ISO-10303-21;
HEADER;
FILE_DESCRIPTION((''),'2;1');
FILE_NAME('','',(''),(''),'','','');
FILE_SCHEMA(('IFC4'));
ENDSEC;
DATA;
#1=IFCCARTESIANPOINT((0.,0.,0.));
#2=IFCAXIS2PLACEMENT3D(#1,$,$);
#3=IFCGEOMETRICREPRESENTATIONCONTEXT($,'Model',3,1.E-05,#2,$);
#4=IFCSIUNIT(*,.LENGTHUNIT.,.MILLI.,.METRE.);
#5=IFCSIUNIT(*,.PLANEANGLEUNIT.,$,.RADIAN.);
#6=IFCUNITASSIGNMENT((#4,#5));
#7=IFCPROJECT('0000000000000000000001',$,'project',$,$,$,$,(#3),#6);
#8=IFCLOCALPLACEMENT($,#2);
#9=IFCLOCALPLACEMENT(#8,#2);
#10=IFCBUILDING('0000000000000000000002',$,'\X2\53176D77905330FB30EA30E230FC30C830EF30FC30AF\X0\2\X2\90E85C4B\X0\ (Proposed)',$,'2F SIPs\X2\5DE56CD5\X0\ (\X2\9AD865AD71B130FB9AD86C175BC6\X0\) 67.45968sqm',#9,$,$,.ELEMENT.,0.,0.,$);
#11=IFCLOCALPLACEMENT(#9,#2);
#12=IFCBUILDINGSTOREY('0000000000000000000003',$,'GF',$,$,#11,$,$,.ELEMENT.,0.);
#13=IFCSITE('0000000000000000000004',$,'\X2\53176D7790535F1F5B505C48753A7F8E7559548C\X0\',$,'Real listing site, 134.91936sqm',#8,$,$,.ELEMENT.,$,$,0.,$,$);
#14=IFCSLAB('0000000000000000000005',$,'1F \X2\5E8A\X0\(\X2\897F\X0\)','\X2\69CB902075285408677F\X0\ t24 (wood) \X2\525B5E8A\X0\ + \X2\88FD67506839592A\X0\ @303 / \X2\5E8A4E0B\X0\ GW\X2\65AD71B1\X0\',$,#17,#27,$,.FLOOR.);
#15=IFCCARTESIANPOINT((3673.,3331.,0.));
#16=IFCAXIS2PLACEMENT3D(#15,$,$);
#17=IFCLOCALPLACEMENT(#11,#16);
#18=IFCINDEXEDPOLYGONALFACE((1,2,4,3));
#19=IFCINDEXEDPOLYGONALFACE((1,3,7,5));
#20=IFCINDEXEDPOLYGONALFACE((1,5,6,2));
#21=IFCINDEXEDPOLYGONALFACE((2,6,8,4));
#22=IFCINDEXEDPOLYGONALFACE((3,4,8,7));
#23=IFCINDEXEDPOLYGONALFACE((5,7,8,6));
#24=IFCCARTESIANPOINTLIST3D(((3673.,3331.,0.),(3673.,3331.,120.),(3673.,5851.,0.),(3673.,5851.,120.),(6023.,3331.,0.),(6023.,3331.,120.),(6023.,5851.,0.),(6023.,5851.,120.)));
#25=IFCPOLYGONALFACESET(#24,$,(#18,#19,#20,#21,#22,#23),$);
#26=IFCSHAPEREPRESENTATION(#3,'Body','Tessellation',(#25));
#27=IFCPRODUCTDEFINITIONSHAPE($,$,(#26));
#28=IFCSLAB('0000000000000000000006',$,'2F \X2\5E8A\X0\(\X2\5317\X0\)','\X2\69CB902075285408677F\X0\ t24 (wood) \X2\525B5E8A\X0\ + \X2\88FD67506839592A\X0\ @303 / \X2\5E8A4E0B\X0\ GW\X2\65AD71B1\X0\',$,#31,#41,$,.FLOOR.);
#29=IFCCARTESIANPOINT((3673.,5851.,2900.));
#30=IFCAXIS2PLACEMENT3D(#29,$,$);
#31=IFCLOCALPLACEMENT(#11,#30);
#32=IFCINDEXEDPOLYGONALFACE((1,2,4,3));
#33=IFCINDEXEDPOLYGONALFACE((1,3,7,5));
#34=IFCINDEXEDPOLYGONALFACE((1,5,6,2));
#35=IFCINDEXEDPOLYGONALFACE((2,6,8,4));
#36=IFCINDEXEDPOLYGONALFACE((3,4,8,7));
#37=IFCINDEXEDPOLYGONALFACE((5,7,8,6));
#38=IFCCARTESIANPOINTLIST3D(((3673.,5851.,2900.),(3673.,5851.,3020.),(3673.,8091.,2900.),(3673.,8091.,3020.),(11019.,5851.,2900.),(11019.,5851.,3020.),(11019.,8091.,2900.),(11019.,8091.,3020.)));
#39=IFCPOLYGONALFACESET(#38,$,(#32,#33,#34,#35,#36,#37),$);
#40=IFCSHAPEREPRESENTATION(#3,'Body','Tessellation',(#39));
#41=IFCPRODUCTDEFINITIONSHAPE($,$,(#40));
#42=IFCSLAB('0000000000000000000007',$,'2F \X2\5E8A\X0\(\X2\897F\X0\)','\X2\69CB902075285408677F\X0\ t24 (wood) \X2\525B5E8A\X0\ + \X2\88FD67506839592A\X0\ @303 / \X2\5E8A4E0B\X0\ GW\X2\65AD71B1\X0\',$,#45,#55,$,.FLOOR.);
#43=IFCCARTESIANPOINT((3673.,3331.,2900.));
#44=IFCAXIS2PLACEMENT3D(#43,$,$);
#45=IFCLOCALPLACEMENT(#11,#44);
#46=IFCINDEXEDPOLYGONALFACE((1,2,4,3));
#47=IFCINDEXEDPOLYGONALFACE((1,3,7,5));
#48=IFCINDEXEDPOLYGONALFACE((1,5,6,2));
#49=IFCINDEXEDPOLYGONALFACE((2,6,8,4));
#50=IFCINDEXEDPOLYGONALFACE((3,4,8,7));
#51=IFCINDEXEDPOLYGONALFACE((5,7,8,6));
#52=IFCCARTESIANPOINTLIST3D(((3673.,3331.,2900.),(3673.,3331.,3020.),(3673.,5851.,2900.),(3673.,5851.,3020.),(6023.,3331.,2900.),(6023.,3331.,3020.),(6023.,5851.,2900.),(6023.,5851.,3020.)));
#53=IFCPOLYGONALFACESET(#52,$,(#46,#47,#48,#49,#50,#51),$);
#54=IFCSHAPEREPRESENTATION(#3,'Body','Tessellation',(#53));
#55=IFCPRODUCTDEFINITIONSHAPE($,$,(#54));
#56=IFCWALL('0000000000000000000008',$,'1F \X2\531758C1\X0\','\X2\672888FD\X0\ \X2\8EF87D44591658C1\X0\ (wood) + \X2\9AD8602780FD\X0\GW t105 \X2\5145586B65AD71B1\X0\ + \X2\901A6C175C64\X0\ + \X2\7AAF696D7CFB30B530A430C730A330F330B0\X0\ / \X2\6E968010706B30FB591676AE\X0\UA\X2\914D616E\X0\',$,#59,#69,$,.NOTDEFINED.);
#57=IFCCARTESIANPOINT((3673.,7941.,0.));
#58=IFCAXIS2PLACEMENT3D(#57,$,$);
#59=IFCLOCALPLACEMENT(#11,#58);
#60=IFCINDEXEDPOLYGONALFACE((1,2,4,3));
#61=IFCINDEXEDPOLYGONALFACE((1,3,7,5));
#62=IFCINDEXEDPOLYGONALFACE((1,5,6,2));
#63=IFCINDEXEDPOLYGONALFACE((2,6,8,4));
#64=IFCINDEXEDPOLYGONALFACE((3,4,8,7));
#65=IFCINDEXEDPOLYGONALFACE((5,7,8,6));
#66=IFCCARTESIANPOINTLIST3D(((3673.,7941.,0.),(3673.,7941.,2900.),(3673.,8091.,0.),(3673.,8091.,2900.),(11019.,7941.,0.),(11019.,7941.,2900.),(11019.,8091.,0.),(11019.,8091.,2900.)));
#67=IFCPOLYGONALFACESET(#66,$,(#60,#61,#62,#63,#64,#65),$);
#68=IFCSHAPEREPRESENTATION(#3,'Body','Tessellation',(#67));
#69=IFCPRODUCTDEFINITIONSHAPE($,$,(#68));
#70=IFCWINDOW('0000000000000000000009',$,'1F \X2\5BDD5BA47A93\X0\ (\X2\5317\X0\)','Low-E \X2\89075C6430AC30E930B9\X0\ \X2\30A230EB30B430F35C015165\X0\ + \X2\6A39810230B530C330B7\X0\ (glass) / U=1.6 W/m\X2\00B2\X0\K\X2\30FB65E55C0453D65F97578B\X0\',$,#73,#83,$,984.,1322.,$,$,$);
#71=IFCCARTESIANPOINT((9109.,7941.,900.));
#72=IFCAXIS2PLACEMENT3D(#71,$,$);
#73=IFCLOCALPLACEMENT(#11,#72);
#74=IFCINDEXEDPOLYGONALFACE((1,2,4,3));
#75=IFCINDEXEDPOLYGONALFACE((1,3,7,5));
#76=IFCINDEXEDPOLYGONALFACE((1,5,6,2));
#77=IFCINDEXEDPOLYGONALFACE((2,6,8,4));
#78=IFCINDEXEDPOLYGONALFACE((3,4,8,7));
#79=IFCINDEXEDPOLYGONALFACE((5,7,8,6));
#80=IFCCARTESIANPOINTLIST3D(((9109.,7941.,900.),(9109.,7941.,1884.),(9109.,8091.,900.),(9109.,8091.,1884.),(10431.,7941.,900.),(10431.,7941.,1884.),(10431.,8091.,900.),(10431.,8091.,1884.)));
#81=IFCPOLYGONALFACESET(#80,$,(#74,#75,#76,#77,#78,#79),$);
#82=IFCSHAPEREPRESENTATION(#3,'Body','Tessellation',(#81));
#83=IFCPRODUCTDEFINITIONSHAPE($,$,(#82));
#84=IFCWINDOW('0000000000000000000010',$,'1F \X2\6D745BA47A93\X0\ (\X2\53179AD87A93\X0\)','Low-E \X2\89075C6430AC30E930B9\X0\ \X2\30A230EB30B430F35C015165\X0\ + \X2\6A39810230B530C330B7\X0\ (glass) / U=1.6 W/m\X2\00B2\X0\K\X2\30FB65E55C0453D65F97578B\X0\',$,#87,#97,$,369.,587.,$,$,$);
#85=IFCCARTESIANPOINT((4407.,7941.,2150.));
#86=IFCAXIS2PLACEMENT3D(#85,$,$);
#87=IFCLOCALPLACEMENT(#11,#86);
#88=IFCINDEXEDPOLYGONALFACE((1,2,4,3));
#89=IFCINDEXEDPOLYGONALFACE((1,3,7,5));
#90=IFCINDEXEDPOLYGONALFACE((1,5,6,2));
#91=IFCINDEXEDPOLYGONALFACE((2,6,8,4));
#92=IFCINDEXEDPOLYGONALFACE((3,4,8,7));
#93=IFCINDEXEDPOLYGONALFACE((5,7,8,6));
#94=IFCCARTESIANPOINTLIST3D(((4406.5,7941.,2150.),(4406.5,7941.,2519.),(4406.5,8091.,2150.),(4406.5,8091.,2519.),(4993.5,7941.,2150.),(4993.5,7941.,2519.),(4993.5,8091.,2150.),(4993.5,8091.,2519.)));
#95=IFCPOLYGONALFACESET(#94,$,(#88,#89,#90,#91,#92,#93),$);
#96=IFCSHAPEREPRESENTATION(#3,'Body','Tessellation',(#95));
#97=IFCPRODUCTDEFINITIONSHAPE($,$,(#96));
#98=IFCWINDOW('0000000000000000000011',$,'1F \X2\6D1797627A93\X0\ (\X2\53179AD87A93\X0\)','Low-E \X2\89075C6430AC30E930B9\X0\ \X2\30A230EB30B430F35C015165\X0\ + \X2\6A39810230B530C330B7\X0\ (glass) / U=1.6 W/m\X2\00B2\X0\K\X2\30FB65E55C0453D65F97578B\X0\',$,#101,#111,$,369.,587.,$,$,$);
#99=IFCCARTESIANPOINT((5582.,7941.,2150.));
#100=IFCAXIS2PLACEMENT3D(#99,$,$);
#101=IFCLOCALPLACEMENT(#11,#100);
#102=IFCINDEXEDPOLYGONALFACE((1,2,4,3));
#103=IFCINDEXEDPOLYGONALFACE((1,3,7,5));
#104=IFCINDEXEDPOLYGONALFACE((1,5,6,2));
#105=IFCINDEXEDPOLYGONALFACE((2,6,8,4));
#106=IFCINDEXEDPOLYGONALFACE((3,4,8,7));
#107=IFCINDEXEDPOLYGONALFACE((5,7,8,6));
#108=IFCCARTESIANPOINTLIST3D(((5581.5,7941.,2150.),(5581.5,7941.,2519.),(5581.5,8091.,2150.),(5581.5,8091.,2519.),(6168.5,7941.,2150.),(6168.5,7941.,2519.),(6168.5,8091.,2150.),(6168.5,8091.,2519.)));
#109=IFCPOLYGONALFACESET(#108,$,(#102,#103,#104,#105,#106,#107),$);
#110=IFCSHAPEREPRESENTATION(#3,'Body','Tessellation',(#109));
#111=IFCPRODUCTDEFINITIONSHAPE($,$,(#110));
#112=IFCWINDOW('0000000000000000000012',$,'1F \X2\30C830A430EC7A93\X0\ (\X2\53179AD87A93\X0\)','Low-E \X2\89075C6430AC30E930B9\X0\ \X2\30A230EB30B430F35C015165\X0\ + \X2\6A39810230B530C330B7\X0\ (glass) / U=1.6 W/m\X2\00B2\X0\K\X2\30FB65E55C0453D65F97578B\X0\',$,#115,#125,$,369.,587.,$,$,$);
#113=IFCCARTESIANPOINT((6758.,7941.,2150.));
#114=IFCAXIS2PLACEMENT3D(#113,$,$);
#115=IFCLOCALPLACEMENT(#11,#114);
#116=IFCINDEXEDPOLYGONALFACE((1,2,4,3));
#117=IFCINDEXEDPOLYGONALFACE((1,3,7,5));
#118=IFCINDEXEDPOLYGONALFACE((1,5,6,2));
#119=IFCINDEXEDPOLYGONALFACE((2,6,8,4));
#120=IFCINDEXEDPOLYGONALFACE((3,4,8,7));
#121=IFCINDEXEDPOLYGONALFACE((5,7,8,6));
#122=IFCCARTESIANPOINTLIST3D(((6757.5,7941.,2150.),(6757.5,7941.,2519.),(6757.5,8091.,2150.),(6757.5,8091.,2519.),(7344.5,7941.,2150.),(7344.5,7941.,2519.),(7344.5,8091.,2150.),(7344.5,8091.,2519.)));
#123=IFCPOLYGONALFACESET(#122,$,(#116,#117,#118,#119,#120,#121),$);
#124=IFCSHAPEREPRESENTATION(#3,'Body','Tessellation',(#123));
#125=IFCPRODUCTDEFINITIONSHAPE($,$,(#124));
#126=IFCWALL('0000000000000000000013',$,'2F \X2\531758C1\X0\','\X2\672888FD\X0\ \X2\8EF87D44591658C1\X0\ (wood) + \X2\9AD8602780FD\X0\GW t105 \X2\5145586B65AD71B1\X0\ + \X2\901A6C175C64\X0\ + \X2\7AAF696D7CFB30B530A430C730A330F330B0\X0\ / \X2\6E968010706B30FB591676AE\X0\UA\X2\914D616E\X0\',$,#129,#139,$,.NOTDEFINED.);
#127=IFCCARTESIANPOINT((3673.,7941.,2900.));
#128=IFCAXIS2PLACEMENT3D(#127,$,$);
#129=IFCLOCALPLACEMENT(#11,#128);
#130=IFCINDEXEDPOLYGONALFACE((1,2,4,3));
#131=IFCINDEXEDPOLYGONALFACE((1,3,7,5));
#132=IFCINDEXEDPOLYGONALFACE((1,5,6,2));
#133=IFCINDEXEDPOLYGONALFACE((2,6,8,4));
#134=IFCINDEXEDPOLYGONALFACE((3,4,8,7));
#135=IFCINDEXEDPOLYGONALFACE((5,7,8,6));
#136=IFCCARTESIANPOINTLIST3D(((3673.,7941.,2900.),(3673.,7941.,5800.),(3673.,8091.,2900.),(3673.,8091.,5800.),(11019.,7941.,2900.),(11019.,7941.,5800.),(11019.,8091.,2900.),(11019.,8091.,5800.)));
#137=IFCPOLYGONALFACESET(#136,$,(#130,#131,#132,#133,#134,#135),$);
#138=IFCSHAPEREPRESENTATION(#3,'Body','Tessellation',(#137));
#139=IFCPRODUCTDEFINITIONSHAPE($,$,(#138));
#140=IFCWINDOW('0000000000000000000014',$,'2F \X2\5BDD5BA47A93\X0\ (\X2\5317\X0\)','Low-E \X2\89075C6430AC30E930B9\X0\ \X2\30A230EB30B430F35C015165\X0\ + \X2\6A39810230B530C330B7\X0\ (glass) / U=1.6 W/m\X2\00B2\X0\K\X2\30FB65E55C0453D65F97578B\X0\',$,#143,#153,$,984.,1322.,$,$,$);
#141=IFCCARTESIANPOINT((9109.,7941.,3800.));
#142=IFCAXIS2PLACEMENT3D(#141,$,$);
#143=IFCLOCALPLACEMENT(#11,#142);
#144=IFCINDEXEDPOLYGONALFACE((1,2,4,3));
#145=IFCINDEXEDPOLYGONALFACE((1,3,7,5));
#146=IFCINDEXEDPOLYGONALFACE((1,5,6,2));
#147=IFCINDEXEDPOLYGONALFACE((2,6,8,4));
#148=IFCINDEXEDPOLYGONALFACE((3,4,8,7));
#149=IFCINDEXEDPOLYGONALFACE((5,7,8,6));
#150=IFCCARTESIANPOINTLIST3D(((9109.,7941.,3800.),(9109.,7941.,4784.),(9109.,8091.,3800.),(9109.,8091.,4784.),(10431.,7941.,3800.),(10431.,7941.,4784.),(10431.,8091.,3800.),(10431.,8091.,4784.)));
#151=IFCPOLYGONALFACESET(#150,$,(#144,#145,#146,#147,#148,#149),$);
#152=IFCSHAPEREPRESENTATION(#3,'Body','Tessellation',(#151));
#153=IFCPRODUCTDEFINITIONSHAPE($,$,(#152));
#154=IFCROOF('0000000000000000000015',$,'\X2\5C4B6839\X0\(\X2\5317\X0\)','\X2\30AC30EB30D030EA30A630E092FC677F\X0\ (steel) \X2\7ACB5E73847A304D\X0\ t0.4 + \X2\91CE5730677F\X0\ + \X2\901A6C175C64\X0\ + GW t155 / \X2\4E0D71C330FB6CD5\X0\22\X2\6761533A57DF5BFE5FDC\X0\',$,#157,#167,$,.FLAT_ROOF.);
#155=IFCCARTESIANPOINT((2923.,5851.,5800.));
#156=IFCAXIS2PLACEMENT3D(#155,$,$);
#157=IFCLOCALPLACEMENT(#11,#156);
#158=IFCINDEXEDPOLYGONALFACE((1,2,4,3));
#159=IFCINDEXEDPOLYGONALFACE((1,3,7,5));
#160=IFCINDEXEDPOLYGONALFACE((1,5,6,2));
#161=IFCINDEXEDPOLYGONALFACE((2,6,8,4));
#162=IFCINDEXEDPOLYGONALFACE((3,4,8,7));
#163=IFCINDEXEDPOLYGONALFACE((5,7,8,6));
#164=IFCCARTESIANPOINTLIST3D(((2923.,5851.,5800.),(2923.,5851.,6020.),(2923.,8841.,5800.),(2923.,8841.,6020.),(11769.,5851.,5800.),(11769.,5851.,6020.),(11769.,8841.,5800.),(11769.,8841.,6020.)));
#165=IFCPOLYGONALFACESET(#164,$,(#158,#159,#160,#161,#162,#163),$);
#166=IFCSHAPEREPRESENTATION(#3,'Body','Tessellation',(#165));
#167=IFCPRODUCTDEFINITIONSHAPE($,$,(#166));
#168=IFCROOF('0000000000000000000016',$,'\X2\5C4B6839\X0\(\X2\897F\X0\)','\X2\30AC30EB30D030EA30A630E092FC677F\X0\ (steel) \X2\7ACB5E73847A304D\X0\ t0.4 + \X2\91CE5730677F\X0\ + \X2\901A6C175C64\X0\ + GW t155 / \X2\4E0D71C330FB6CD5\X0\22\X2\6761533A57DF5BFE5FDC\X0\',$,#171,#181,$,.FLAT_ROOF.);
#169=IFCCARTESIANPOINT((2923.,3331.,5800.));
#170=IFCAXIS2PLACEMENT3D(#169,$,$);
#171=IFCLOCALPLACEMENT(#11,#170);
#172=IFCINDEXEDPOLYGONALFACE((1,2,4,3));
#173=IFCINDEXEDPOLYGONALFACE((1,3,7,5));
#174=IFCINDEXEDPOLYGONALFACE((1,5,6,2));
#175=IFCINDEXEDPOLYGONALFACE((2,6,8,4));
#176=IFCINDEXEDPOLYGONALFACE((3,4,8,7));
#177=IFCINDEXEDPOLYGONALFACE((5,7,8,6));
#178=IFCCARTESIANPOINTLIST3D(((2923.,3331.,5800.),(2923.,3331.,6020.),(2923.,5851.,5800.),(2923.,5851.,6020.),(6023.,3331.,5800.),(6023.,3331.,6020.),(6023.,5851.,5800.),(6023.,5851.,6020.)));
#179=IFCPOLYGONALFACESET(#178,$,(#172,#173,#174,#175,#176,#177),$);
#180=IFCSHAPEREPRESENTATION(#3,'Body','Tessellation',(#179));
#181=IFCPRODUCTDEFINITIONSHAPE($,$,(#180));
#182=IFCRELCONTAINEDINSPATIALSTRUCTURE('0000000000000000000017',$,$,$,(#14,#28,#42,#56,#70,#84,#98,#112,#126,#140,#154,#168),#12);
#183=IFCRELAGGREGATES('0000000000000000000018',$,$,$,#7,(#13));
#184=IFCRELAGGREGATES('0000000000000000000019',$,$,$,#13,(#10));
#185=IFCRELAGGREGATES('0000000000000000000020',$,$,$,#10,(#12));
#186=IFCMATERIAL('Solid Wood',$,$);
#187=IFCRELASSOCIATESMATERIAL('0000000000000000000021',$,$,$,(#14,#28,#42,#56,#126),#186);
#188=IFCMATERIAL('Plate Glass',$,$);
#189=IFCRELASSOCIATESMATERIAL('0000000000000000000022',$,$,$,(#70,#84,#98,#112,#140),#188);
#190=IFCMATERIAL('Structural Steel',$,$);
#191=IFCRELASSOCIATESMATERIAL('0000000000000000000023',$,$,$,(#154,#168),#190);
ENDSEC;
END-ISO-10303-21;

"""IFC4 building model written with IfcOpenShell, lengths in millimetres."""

from ifc_helpers import new_model, si_unit, frame, frame_2d, origin, place, context, project, spatial, rectangle, extrude, material, element, fill, save


model = new_model("IFC4")

# Units and contexts
model_context = context("Model", 3, precision=1e-05, world=origin())
ifc_project = project(units=[si_unit("LENGTHUNIT", "METRE", prefix="MILLI"), si_unit("PLANEANGLEUNIT", "RADIAN")], contexts=[model_context])

# Site, building, storey
site_placement = place(None, origin())
site = spatial("IfcSite", under=ifc_project, at=site_placement, Name="北海道弟子屈町美留和", ObjectType="Real listing site, 134.91936sqm", CompositionType="ELEMENT", RefElevation=0.0)
building_placement = place(site_placement, origin())
building = spatial("IfcBuilding", under=site, at=building_placement, Name="北海道・リモートワーク2部屋 (Proposed)", ObjectType="2F SIPs工法 (高断熱・高気密) 67.45968sqm", CompositionType="ELEMENT", ElevationOfRefHeight=0.0, ElevationOfTerrain=0.0)
storey_placement = place(building_placement, origin())
storey = spatial("IfcBuildingStorey", under=building, at=storey_placement, Name="GF", CompositionType="ELEMENT", Elevation=0.0)

# Slabs
ifc_material_1 = material(Name="Solid Wood")
slab_1_placement = place(storey_placement, frame((3673.0, 3331.0, 0.0)))
element("IfcSlab", 1, at=slab_1_placement, inside=storey, material=ifc_material_1, Name="1F 床(西)", Description="構造用合板 t24 (wood) 剛床 + 製材根太 @303 / 床下 GW断熱", PredefinedType="FLOOR", context=model_context, shape_type="SweptSolid", body=[
    extrude(rectangle(XDim=2350.0, YDim=2520.0, at=frame_2d((1175.0, 1260.0))), frame((3673.0, 3331.0, 0.0)), (0.0, 0.0, 1.0), 120.0),
])
slab_2_placement = place(storey_placement, frame((3673.0, 5851.0, 2900.0)))
element("IfcSlab", 2, at=slab_2_placement, inside=storey, material=ifc_material_1, Name="2F 床(北)", Description="構造用合板 t24 (wood) 剛床 + 製材根太 @303 / 床下 GW断熱", PredefinedType="FLOOR", context=model_context, shape_type="SweptSolid", body=[
    extrude(rectangle(XDim=7346.0, YDim=2240.0, at=frame_2d((3673.0, 1120.0))), frame((3673.0, 5851.0, 2900.0)), (0.0, 0.0, 1.0), 120.0),
])
slab_3_placement = place(storey_placement, frame((3673.0, 3331.0, 2900.0)))
element("IfcSlab", 3, at=slab_3_placement, inside=storey, material=ifc_material_1, Name="2F 床(西)", Description="構造用合板 t24 (wood) 剛床 + 製材根太 @303 / 床下 GW断熱", PredefinedType="FLOOR", context=model_context, shape_type="SweptSolid", body=[
    extrude(rectangle(XDim=2350.0, YDim=2520.0, at=frame_2d((1175.0, 1260.0))), frame((3673.0, 3331.0, 2900.0)), (0.0, 0.0, 1.0), 120.0),
])

# Wall, openings, windows
wall_1_placement = place(storey_placement, frame((3673.0, 7941.0, 0.0)))
wall_1 = element("IfcWall", 4, at=wall_1_placement, inside=storey, material=ifc_material_1, Name="1F 北壁", Description="木製 軸組外壁 (wood) + 高性能GW t105 充填断熱 + 通気層 + 窯業系サイディング / 準耐火・外皮UA配慮", PredefinedType="NOTDEFINED", context=model_context, shape_type="SweptSolid", body=[
    extrude(rectangle(XDim=7346.0, YDim=150.0, at=frame_2d((3673.0, 75.0))), frame((3673.0, 7941.0, 0.0)), (0.0, 0.0, 1.0), 2900.0),
])
opening_1_placement = place(storey_placement, frame((9109.0, 7941.0, 900.0)))
opening_1 = element("IfcOpeningElement", 5, at=opening_1_placement, cuts=wall_1, PredefinedType="NOTDEFINED", context=model_context, shape_type="SweptSolid", body=[
    extrude(rectangle(XDim=1322.0, YDim=150.0, at=frame_2d((661.0, 75.0))), frame((9109.0, 7941.0, 900.0)), (0.0, 0.0, 1.0), 984.0),
])
opening_2_placement = place(storey_placement, frame((4407.0, 7941.0, 2150.0)))
opening_2 = element("IfcOpeningElement", 6, at=opening_2_placement, cuts=wall_1, PredefinedType="NOTDEFINED", context=model_context, shape_type="SweptSolid", body=[
    extrude(rectangle(XDim=587.0, YDim=150.0, at=frame_2d((293.0, 75.0))), frame((4407.0, 7941.0, 2150.0)), (0.0, 0.0, 1.0), 369.0),
])
opening_3_placement = place(storey_placement, frame((5582.0, 7941.0, 2150.0)))
opening_3 = element("IfcOpeningElement", 7, at=opening_3_placement, cuts=wall_1, PredefinedType="NOTDEFINED", context=model_context, shape_type="SweptSolid", body=[
    extrude(rectangle(XDim=587.0, YDim=150.0, at=frame_2d((293.0, 75.0))), frame((5582.0, 7941.0, 2150.0)), (0.0, 0.0, 1.0), 369.0),
])
opening_4_placement = place(storey_placement, frame((6758.0, 7941.0, 2150.0)))
opening_4 = element("IfcOpeningElement", 8, at=opening_4_placement, cuts=wall_1, PredefinedType="NOTDEFINED", context=model_context, shape_type="SweptSolid", body=[
    extrude(rectangle(XDim=587.0, YDim=150.0, at=frame_2d((293.0, 75.0))), frame((6758.0, 7941.0, 2150.0)), (0.0, 0.0, 1.0), 369.0),
])
ifc_material_2 = material(Name="Plate Glass")
window_1_placement = place(storey_placement, frame((9109.0, 7941.0, 900.0)))
window_1 = element("IfcWindow", 9, at=window_1_placement, inside=storey, material=ifc_material_2, Name="1F 寝室窓 (北)", Description="Low-E 複層ガラス アルゴン封入 + 樹脂サッシ (glass) / U=1.6 W/m²K・日射取得型", OverallHeight=984.0, OverallWidth=1322.0, context=model_context, shape_type="SweptSolid", body=[
    extrude(rectangle(XDim=1322.0, YDim=150.0, at=frame_2d((661.0, 75.0))), frame((9109.0, 7941.0, 900.0)), (0.0, 0.0, 1.0), 984.0),
])
fill(opening_1, window_1)
window_2_placement = place(storey_placement, frame((4407.0, 7941.0, 2150.0)))
window_2 = element("IfcWindow", 10, at=window_2_placement, inside=storey, material=ifc_material_2, Name="1F 浴室窓 (北高窓)", Description="Low-E 複層ガラス アルゴン封入 + 樹脂サッシ (glass) / U=1.6 W/m²K・日射取得型", OverallHeight=369.0, OverallWidth=587.0, context=model_context, shape_type="SweptSolid", body=[
    extrude(rectangle(XDim=587.0, YDim=150.0, at=frame_2d((293.0, 75.0))), frame((4407.0, 7941.0, 2150.0)), (0.0, 0.0, 1.0), 369.0),
])
fill(opening_2, window_2)
window_3_placement = place(storey_placement, frame((5582.0, 7941.0, 2150.0)))
window_3 = element("IfcWindow", 11, at=window_3_placement, inside=storey, material=ifc_material_2, Name="1F 洗面窓 (北高窓)", Description="Low-E 複層ガラス アルゴン封入 + 樹脂サッシ (glass) / U=1.6 W/m²K・日射取得型", OverallHeight=369.0, OverallWidth=587.0, context=model_context, shape_type="SweptSolid", body=[
    extrude(rectangle(XDim=587.0, YDim=150.0, at=frame_2d((293.0, 75.0))), frame((5582.0, 7941.0, 2150.0)), (0.0, 0.0, 1.0), 369.0),
])
fill(opening_3, window_3)
window_4_placement = place(storey_placement, frame((6758.0, 7941.0, 2150.0)))
window_4 = element("IfcWindow", 12, at=window_4_placement, inside=storey, material=ifc_material_2, Name="1F トイレ窓 (北高窓)", Description="Low-E 複層ガラス アルゴン封入 + 樹脂サッシ (glass) / U=1.6 W/m²K・日射取得型", OverallHeight=369.0, OverallWidth=587.0, context=model_context, shape_type="SweptSolid", body=[
    extrude(rectangle(XDim=587.0, YDim=150.0, at=frame_2d((293.0, 75.0))), frame((6758.0, 7941.0, 2150.0)), (0.0, 0.0, 1.0), 369.0),
])
fill(opening_4, window_4)

# Wall, opening, window
wall_2_placement = place(storey_placement, frame((3673.0, 7941.0, 2900.0)))
wall_2 = element("IfcWall", 13, at=wall_2_placement, inside=storey, material=ifc_material_1, Name="2F 北壁", Description="木製 軸組外壁 (wood) + 高性能GW t105 充填断熱 + 通気層 + 窯業系サイディング / 準耐火・外皮UA配慮", PredefinedType="NOTDEFINED", context=model_context, shape_type="SweptSolid", body=[
    extrude(rectangle(XDim=7346.0, YDim=150.0, at=frame_2d((3673.0, 75.0))), frame((3673.0, 7941.0, 2900.0)), (0.0, 0.0, 1.0), 2900.0),
])
opening_5_placement = place(storey_placement, frame((9109.0, 7941.0, 3800.0)))
opening_5 = element("IfcOpeningElement", 14, at=opening_5_placement, cuts=wall_2, PredefinedType="NOTDEFINED", context=model_context, shape_type="SweptSolid", body=[
    extrude(rectangle(XDim=1322.0, YDim=150.0, at=frame_2d((661.0, 75.0))), frame((9109.0, 7941.0, 3800.0)), (0.0, 0.0, 1.0), 984.0),
])
window_5_placement = place(storey_placement, frame((9109.0, 7941.0, 3800.0)))
window_5 = element("IfcWindow", 15, at=window_5_placement, inside=storey, material=ifc_material_2, Name="2F 寝室窓 (北)", Description="Low-E 複層ガラス アルゴン封入 + 樹脂サッシ (glass) / U=1.6 W/m²K・日射取得型", OverallHeight=984.0, OverallWidth=1322.0, context=model_context, shape_type="SweptSolid", body=[
    extrude(rectangle(XDim=1322.0, YDim=150.0, at=frame_2d((661.0, 75.0))), frame((9109.0, 7941.0, 3800.0)), (0.0, 0.0, 1.0), 984.0),
])
fill(opening_5, window_5)

# Roofs
ifc_material_3 = material(Name="Structural Steel")
for number, where, name in (
    (16, (2923.0, 5851.0, 5800.0), "屋根(北)"),
):
    element("IfcRoof", number, at=place(storey_placement, frame(where)), inside=storey, material=ifc_material_3, Name=name, Description="ガルバリウム鋼板 (steel) 立平葺き t0.4 + 野地板 + 通気層 + GW t155 / 不燃・法22条区域対応", PredefinedType="FLAT_ROOF", context=model_context, shape_type="SweptSolid", body=[
        extrude(rectangle(XDim=8846.0, YDim=2990.0, at=frame_2d((4423.0, 1495.0))), frame((2923.0, 5851.0, 5800.0)), (0.0, 0.0, 1.0), 220.0),
    ])
roof_placement = place(storey_placement, frame((2923.0, 3331.0, 5800.0)))
element("IfcRoof", 17, at=roof_placement, inside=storey, material=ifc_material_3, Name="屋根(西)", Description="ガルバリウム鋼板 (steel) 立平葺き t0.4 + 野地板 + 通気層 + GW t155 / 不燃・法22条区域対応", PredefinedType="FLAT_ROOF", context=model_context, shape_type="SweptSolid", body=[
    extrude(rectangle(XDim=3100.0, YDim=2520.0, at=frame_2d((1550.0, 1260.0))), frame((2923.0, 3331.0, 5800.0)), (0.0, 0.0, 1.0), 220.0),
])

save(model, "model.ifc")
